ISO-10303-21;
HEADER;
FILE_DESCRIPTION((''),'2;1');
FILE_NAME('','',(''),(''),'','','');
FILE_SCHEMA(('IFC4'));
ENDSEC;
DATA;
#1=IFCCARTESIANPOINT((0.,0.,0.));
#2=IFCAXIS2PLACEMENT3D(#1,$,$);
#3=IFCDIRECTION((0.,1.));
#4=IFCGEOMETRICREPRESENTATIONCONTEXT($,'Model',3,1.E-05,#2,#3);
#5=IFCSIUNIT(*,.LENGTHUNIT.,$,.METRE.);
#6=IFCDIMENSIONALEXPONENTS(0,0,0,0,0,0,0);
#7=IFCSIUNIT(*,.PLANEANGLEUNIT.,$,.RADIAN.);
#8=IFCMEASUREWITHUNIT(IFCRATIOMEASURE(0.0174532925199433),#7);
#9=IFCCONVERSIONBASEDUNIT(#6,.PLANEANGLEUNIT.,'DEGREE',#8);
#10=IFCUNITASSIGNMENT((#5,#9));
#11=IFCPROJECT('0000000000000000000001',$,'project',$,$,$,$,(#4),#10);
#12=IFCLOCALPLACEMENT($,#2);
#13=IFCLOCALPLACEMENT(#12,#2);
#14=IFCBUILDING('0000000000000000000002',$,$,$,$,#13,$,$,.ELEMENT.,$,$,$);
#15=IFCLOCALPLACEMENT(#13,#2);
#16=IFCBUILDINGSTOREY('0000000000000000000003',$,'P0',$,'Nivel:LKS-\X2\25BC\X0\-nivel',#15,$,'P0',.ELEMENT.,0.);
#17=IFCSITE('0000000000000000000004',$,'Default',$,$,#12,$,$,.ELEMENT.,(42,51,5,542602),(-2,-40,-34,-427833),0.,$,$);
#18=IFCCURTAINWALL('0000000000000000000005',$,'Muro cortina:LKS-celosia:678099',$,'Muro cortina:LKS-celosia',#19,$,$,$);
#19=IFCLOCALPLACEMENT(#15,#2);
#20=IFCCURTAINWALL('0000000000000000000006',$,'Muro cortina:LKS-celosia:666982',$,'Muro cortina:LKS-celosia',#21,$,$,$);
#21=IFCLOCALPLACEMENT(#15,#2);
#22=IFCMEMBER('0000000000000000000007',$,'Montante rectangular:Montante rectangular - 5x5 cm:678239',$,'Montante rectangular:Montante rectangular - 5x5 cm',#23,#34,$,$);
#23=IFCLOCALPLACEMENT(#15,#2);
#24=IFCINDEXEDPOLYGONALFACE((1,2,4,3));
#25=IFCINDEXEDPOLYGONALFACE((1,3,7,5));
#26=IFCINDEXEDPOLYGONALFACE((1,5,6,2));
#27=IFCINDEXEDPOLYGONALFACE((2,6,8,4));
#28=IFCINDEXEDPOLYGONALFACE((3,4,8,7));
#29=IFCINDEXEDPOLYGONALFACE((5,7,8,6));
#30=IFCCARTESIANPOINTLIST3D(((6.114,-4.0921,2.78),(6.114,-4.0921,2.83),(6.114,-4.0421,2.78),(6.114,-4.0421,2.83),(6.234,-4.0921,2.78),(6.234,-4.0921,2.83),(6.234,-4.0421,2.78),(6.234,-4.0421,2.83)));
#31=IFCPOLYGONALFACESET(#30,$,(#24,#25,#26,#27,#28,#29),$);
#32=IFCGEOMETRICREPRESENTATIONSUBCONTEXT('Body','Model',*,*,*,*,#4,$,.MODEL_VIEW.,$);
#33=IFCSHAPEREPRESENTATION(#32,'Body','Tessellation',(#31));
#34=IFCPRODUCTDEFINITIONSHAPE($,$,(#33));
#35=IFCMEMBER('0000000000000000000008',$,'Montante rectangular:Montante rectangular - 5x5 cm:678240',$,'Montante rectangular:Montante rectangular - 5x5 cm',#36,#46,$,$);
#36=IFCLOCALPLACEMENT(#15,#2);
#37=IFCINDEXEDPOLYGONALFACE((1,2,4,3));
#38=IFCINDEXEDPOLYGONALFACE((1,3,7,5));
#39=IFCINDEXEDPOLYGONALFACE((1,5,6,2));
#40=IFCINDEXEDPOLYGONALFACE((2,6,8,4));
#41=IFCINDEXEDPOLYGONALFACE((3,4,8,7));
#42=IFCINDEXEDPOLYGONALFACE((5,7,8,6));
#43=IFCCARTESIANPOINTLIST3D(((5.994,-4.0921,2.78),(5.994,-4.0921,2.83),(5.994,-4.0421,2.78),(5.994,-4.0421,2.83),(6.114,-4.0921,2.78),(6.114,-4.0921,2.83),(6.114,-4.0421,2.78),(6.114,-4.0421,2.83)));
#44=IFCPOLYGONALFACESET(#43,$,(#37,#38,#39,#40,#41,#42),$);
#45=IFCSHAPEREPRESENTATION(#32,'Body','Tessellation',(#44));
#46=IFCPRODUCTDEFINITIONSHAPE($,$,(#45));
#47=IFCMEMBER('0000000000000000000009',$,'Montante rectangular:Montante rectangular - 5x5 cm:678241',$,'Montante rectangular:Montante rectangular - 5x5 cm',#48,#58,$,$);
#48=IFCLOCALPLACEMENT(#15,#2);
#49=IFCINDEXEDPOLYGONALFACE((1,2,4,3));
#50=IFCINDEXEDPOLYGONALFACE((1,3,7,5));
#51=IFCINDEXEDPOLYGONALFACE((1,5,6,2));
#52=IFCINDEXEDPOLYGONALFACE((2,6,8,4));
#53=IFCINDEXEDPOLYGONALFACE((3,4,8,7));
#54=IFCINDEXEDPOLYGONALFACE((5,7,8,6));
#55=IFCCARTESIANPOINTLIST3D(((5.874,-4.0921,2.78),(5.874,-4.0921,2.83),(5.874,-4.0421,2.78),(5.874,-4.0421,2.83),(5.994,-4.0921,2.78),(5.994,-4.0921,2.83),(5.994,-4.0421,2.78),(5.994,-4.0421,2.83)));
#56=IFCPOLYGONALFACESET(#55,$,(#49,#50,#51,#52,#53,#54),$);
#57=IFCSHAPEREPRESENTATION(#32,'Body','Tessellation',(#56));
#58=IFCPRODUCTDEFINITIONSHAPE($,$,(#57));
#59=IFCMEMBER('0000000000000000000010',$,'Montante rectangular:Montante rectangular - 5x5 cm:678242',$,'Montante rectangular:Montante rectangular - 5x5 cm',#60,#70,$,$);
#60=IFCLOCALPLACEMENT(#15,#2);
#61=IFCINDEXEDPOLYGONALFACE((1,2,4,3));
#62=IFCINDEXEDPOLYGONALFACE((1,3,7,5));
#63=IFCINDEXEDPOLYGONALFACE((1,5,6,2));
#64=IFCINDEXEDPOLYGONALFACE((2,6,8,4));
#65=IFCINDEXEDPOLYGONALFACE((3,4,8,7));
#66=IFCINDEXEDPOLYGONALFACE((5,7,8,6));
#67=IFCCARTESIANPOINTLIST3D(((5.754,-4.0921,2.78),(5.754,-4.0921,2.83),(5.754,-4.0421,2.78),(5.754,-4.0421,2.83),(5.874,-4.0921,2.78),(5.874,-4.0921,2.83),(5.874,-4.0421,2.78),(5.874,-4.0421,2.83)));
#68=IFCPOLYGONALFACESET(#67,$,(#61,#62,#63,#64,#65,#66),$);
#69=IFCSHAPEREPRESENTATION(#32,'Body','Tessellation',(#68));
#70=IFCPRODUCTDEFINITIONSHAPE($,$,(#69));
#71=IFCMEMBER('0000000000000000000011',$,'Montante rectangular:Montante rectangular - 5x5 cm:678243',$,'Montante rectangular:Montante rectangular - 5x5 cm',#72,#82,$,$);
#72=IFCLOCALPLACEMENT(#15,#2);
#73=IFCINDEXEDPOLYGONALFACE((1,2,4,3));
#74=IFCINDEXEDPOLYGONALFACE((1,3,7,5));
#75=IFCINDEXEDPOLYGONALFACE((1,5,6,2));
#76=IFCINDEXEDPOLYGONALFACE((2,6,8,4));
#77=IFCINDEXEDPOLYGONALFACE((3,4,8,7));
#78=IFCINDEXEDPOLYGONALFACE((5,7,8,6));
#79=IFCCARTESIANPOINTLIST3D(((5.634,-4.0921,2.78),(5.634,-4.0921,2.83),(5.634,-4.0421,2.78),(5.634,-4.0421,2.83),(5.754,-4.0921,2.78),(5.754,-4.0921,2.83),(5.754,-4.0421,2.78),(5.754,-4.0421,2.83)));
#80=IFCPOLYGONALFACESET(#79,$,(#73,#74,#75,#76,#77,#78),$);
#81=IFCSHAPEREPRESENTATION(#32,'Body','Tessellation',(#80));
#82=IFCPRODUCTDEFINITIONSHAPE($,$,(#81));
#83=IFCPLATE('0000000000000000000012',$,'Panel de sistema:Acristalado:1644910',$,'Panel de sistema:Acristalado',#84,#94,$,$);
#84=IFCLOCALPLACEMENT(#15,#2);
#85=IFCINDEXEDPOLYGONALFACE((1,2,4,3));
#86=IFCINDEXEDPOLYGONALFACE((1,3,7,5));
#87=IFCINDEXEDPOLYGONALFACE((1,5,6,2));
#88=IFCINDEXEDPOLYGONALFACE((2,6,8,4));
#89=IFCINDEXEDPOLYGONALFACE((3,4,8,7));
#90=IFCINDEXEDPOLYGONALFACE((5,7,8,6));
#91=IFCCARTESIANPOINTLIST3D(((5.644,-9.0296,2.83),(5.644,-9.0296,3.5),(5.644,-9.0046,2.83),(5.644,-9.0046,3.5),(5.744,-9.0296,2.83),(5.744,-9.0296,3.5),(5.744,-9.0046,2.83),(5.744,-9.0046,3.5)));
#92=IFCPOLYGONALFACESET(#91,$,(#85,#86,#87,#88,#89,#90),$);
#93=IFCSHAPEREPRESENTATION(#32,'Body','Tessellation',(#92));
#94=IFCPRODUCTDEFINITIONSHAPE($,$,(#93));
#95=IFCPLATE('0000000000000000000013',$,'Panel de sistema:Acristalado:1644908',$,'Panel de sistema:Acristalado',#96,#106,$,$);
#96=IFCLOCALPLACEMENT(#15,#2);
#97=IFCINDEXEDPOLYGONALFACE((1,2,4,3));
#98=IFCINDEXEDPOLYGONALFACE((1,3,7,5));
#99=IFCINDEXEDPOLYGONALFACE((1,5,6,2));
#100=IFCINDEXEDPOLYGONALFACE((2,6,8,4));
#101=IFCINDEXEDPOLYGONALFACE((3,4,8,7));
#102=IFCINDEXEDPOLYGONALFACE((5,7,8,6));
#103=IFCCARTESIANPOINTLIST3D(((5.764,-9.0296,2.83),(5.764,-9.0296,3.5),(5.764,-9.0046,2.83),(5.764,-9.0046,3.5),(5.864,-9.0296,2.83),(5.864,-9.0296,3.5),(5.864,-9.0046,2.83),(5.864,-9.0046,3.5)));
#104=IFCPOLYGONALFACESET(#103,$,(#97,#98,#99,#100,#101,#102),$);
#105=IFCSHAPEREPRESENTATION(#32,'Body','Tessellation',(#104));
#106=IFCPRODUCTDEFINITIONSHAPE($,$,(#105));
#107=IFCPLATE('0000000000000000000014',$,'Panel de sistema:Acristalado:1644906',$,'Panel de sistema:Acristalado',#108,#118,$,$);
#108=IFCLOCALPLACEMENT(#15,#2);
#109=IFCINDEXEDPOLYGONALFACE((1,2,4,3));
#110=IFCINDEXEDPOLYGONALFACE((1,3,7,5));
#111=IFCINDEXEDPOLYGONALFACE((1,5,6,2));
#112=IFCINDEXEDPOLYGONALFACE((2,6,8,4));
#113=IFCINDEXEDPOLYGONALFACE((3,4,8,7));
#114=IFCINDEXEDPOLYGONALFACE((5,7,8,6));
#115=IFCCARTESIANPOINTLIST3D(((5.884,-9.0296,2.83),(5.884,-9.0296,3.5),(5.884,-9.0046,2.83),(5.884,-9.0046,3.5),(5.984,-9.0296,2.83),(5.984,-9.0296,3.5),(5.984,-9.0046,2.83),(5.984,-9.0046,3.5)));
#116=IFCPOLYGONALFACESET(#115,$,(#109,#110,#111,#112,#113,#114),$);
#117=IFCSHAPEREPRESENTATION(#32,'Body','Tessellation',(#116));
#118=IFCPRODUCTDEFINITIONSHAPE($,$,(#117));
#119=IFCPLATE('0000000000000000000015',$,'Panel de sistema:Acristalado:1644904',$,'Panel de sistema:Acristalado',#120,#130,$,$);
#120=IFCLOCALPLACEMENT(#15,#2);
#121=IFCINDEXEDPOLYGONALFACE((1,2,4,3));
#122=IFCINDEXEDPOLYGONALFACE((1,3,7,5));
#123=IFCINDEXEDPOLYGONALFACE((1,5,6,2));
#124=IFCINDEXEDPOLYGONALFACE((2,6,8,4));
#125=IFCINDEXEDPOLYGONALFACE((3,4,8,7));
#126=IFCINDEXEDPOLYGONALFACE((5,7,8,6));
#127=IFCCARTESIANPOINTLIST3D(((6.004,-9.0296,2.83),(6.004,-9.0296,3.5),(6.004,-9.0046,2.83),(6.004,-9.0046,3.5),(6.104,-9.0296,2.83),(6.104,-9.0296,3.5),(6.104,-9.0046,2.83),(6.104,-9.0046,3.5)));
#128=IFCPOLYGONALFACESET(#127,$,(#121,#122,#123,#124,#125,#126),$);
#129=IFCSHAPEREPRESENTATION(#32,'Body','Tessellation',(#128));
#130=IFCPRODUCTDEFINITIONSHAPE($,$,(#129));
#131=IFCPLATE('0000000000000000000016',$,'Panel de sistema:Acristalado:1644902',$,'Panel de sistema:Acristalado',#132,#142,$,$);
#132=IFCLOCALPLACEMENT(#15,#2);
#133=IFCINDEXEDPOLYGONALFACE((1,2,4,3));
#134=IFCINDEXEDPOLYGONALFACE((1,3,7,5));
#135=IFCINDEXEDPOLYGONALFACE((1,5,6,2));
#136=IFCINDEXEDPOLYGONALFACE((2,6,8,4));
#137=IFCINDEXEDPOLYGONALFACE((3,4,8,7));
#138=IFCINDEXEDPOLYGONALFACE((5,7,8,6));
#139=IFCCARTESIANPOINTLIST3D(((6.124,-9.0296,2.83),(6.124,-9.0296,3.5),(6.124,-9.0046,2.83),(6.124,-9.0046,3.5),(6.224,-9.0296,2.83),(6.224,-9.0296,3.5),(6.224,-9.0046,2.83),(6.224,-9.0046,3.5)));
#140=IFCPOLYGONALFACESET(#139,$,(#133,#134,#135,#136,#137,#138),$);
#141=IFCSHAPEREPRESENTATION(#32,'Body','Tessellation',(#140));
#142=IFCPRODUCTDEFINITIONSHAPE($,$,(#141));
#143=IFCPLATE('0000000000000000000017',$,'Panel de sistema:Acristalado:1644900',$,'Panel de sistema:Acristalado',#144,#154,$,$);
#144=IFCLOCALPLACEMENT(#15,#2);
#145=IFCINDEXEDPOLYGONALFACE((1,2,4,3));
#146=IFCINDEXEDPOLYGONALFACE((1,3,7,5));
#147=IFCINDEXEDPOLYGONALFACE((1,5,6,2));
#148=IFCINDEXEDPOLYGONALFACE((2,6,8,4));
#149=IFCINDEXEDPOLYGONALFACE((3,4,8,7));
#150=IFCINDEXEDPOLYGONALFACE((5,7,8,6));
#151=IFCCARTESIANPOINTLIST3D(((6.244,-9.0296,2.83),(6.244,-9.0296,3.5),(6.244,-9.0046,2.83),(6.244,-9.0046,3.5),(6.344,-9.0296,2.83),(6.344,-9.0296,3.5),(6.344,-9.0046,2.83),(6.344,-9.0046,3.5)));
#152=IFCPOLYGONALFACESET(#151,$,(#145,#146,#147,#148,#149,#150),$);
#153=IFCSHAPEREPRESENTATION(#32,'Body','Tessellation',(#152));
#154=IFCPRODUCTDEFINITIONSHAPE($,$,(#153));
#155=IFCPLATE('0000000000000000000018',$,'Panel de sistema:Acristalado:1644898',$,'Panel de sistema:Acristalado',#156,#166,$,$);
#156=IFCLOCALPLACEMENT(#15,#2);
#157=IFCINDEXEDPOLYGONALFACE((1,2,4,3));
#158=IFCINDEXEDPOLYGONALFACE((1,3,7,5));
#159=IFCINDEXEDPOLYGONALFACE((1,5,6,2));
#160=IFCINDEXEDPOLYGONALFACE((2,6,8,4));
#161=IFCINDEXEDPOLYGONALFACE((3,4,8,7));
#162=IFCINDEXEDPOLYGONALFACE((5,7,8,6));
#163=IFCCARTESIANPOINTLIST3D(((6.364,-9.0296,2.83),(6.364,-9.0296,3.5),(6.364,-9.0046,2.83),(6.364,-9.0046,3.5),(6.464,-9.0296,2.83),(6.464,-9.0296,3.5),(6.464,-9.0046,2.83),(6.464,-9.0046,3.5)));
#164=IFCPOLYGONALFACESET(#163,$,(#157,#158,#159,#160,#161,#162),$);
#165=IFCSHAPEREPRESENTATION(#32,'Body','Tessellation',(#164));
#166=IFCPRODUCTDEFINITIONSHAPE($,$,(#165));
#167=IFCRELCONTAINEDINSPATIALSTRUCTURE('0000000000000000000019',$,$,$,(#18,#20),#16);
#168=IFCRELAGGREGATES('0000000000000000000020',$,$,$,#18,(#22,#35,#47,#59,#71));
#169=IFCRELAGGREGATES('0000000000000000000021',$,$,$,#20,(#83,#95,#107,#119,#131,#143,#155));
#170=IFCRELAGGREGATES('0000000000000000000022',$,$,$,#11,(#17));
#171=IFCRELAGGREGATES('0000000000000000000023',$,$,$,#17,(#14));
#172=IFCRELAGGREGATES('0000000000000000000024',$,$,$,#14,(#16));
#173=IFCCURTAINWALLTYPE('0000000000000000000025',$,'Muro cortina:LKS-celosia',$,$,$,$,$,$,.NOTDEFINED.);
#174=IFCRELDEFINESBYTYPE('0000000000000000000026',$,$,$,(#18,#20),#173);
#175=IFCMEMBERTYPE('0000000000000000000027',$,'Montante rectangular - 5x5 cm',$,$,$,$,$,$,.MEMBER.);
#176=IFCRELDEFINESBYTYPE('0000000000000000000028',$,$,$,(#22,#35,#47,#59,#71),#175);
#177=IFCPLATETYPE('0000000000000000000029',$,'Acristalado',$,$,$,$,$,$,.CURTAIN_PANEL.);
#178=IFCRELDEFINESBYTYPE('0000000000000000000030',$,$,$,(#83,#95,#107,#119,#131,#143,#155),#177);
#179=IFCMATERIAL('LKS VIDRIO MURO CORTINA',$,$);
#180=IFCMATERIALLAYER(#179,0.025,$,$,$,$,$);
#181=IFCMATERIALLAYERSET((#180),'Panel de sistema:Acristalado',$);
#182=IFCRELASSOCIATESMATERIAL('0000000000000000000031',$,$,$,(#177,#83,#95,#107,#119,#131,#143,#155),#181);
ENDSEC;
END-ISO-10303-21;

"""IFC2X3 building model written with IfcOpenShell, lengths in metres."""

from ifc_helpers import new_model, entity, si_unit, converted_unit, direction, frame, origin, origin_2d_with_axis, place, context, subcontext, project, spatial, rectangle, extrude, source, transform, mapped, material, layer, layer_set, layer_usage, type_object, type_shapes, element, aggregate, save


model = new_model("IFC2X3")

# Units and contexts
model_context = context("Model", 3, precision=1e-05, world=origin(), true_north=direction((0.0, 1.0)))
body_context = subcontext(model_context, "Body", "Model", "MODEL_VIEW")
ifc_project = project(units=[si_unit("LENGTHUNIT", "METRE"), converted_unit("PLANEANGLEUNIT", "DEGREE", entity("IfcRatioMeasure", 0.0174532925199433), si_unit("PLANEANGLEUNIT", "RADIAN"), dimensions=[0, 0, 0, 0, 0, 0, 0])], contexts=[model_context])

# Site, building, storey
site_placement = place(None, origin())
site = spatial("IfcSite", under=ifc_project, at=site_placement, Name="Default", CompositionType="ELEMENT", RefLatitude=(42, 51, 5, 542602), RefLongitude=(-2, -40, -34, -427833), RefElevation=0.0)
building_placement = place(site_placement, origin())
building = spatial("IfcBuilding", under=site, at=building_placement, CompositionType="ELEMENT")
storey_placement = place(building_placement, origin())
storey = spatial("IfcBuildingStorey", under=building, at=storey_placement, Name="P0", ObjectType="Nivel:LKS-▼-nivel", LongName="P0", CompositionType="ELEMENT", Elevation=0.0)

# Curtain wall
curtain_wall_type = type_object("IfcCurtainWallType", Name="Muro cortina:LKS-celosia", PredefinedType="NOTDEFINED")
curtain_wall_1_placement = place(storey_placement, origin())
curtain_wall_1 = element("IfcCurtainWall", 1, at=curtain_wall_1_placement, inside=storey, type_object=curtain_wall_type, Name="Muro cortina:LKS-celosia:678099", ObjectType="Muro cortina:LKS-celosia")

# Curtain wall
curtain_wall_2_placement = place(storey_placement, origin())
curtain_wall_2 = element("IfcCurtainWall", 2, at=curtain_wall_2_placement, inside=storey, type_object=curtain_wall_type, Name="Muro cortina:LKS-celosia:666982", ObjectType="Muro cortina:LKS-celosia")
member_type_1 = type_object("IfcMemberType", Name="Montante rectangular - 5x5 cm", PredefinedType="MEMBER")
shared_shape_1 = source(origin(), body_context, "Body", "SweptSolid", [
    extrude(rectangle(XDim=0.05, YDim=0.05, at=origin_2d_with_axis()), frame((-0.025, -0.1, -0.12), z_axis=(0.0, 0.0, 1.0), x_axis=(0.0, -1.0, 0.0)), (0.0, 0.0, 1.0), 0.12),
])
type_shapes(member_type_1, [shared_shape_1])

# Members
member_1_placement = place(storey_placement, frame((6.114, -4.1671, 2.78), z_axis=(-1.0, 0.0, 0.0), x_axis=(0.0, 0.0, -1.0)))
member_1 = element("IfcMember", 3, at=member_1_placement, type_object=member_type_1, Name="Montante rectangular:Montante rectangular - 5x5 cm:678239", ObjectType="Montante rectangular:Montante rectangular - 5x5 cm", context=body_context, shape_type="MappedRepresentation", body=[
    mapped(shared_shape_1, transform((0.0, 0.0, 0.0), scale=1.0)),
])
member_2_placement = place(storey_placement, frame((5.994, -4.1671, 2.78), z_axis=(-1.0, 0.0, 0.0), x_axis=(0.0, 0.0, -1.0)))
member_2 = element("IfcMember", 4, at=member_2_placement, type_object=member_type_1, Name="Montante rectangular:Montante rectangular - 5x5 cm:678240", ObjectType="Montante rectangular:Montante rectangular - 5x5 cm", context=body_context, shape_type="MappedRepresentation", body=[
    mapped(shared_shape_1, transform((0.0, 0.0, 0.0), scale=1.0)),
])
member_3_placement = place(storey_placement, frame((5.874, -4.1671, 2.78), z_axis=(-1.0, 0.0, 0.0), x_axis=(0.0, 0.0, -1.0)))
member_3 = element("IfcMember", 5, at=member_3_placement, type_object=member_type_1, Name="Montante rectangular:Montante rectangular - 5x5 cm:678241", ObjectType="Montante rectangular:Montante rectangular - 5x5 cm", context=body_context, shape_type="MappedRepresentation", body=[
    mapped(shared_shape_1, transform((0.0, 0.0, 0.0), scale=1.0)),
])
member_4_placement = place(storey_placement, frame((5.754, -4.1671, 2.78), z_axis=(-1.0, 0.0, 0.0), x_axis=(0.0, 0.0, -1.0)))
member_4 = element("IfcMember", 6, at=member_4_placement, type_object=member_type_1, Name="Montante rectangular:Montante rectangular - 5x5 cm:678242", ObjectType="Montante rectangular:Montante rectangular - 5x5 cm", context=body_context, shape_type="MappedRepresentation", body=[
    mapped(shared_shape_1, transform((0.0, 0.0, 0.0), scale=1.0)),
])
member_5_placement = place(storey_placement, frame((5.634, -4.1671, 2.78), z_axis=(-1.0, 0.0, 0.0), x_axis=(0.0, 0.0, -1.0)))
member_5 = element("IfcMember", 7, at=member_5_placement, type_object=member_type_1, Name="Montante rectangular:Montante rectangular - 5x5 cm:678243", ObjectType="Montante rectangular:Montante rectangular - 5x5 cm", context=body_context, shape_type="MappedRepresentation", body=[
    mapped(shared_shape_1, transform((0.0, 0.0, 0.0), scale=1.0)),
])
aggregate(curtain_wall_1, [member_1, member_2, member_3, member_4, member_5])

# Plates
ifc_material_1 = material(Name="LKS VIDRIO MURO CORTINA")
ifc_layer_1 = layer(ifc_material_1, 0.025)
ifc_layer_set_1 = layer_set([ifc_layer_1], Name="Panel de sistema:Acristalado")
ifc_layer_usage_1 = layer_usage(ifc_layer_set_1, "AXIS3", "POSITIVE", 0.0)
plate_type = type_object("IfcPlateType", Name="Acristalado", PredefinedType="CURTAIN_PANEL", material=ifc_layer_set_1)
shared_shape_2 = source(origin(), body_context, "Body", "SweptSolid", [
    extrude(rectangle(XDim=0.025, YDim=0.1, at=origin_2d_with_axis()), frame((0.0, 0.0, 0.0), z_axis=(0.0, 0.0, 1.0), x_axis=(0.0, 1.0, 0.0)), (0.0, 0.0, 1.0), 0.67),
])
type_shapes(plate_type, [shared_shape_2])
plate_1_placement = place(curtain_wall_2_placement, frame((5.694, -9.0171, 2.83)))
plate_1 = element("IfcPlate", 8, at=plate_1_placement, type_object=plate_type, material=ifc_layer_usage_1, Name="Panel de sistema:Acristalado:1644910", ObjectType="Panel de sistema:Acristalado", context=body_context, shape_type="MappedRepresentation", body=[
    mapped(shared_shape_2, transform((0.0, 0.0, 0.0), scale=1.0)),
])
ifc_layer_usage_2 = layer_usage(ifc_layer_set_1, "AXIS3", "POSITIVE", 0.0)
plate_2_placement = place(curtain_wall_2_placement, frame((5.814, -9.0171, 2.83)))
plate_2 = element("IfcPlate", 9, at=plate_2_placement, type_object=plate_type, material=ifc_layer_usage_2, Name="Panel de sistema:Acristalado:1644908", ObjectType="Panel de sistema:Acristalado", context=body_context, shape_type="MappedRepresentation", body=[
    mapped(shared_shape_2, transform((0.0, 0.0, 0.0), scale=1.0)),
])
ifc_layer_usage_3 = layer_usage(ifc_layer_set_1, "AXIS3", "POSITIVE", 0.0)
plate_3_placement = place(curtain_wall_2_placement, frame((5.934, -9.0171, 2.83)))
plate_3 = element("IfcPlate", 10, at=plate_3_placement, type_object=plate_type, material=ifc_layer_usage_3, Name="Panel de sistema:Acristalado:1644906", ObjectType="Panel de sistema:Acristalado", context=body_context, shape_type="MappedRepresentation", body=[
    mapped(shared_shape_2, transform((0.0, 0.0, 0.0), scale=1.0)),
])
ifc_layer_usage_4 = layer_usage(ifc_layer_set_1, "AXIS3", "POSITIVE", 0.0)
plate_4_placement = place(curtain_wall_2_placement, frame((6.054, -9.0171, 2.83)))
plate_4 = element("IfcPlate", 11, at=plate_4_placement, type_object=plate_type, material=ifc_layer_usage_4, Name="Panel de sistema:Acristalado:1644904", ObjectType="Panel de sistema:Acristalado", context=body_context, shape_type="MappedRepresentation", body=[
    mapped(shared_shape_2, transform((0.0, 0.0, 0.0), scale=1.0)),
])
ifc_layer_usage_5 = layer_usage(ifc_layer_set_1, "AXIS3", "POSITIVE", 0.0)
plate_5_placement = place(curtain_wall_2_placement, frame((6.174, -9.0171, 2.83)))
plate_5 = element("IfcPlate", 12, at=plate_5_placement, type_object=plate_type, material=ifc_layer_usage_5, Name="Panel de sistema:Acristalado:1644902", ObjectType="Panel de sistema:Acristalado", context=body_context, shape_type="MappedRepresentation", body=[
    mapped(shared_shape_2, transform((0.0, 0.0, 0.0), scale=1.0)),
])
ifc_layer_usage_6 = layer_usage(ifc_layer_set_1, "AXIS3", "POSITIVE", 0.0)
plate_6_placement = place(curtain_wall_2_placement, frame((6.294, -9.0171, 2.83)))
plate_6 = element("IfcPlate", 13, at=plate_6_placement, type_object=plate_type, material=ifc_layer_usage_6, Name="Panel de sistema:Acristalado:1644900", ObjectType="Panel de sistema:Acristalado", context=body_context, shape_type="MappedRepresentation", body=[
    mapped(shared_shape_2, transform((0.0, 0.0, 0.0), scale=1.0)),
])
ifc_layer_usage_7 = layer_usage(ifc_layer_set_1, "AXIS3", "POSITIVE", 0.0)
plate_7_placement = place(curtain_wall_2_placement, frame((6.414, -9.0171, 2.83)))
plate_7 = element("IfcPlate", 14, at=plate_7_placement, type_object=plate_type, material=ifc_layer_usage_7, Name="Panel de sistema:Acristalado:1644898", ObjectType="Panel de sistema:Acristalado", context=body_context, shape_type="MappedRepresentation", body=[
    mapped(shared_shape_2, transform((0.0, 0.0, 0.0), scale=1.0)),
])
aggregate(curtain_wall_2, [plate_1, plate_2, plate_3, plate_4, plate_5, plate_6, plate_7])

save(model, "model.ifc")
